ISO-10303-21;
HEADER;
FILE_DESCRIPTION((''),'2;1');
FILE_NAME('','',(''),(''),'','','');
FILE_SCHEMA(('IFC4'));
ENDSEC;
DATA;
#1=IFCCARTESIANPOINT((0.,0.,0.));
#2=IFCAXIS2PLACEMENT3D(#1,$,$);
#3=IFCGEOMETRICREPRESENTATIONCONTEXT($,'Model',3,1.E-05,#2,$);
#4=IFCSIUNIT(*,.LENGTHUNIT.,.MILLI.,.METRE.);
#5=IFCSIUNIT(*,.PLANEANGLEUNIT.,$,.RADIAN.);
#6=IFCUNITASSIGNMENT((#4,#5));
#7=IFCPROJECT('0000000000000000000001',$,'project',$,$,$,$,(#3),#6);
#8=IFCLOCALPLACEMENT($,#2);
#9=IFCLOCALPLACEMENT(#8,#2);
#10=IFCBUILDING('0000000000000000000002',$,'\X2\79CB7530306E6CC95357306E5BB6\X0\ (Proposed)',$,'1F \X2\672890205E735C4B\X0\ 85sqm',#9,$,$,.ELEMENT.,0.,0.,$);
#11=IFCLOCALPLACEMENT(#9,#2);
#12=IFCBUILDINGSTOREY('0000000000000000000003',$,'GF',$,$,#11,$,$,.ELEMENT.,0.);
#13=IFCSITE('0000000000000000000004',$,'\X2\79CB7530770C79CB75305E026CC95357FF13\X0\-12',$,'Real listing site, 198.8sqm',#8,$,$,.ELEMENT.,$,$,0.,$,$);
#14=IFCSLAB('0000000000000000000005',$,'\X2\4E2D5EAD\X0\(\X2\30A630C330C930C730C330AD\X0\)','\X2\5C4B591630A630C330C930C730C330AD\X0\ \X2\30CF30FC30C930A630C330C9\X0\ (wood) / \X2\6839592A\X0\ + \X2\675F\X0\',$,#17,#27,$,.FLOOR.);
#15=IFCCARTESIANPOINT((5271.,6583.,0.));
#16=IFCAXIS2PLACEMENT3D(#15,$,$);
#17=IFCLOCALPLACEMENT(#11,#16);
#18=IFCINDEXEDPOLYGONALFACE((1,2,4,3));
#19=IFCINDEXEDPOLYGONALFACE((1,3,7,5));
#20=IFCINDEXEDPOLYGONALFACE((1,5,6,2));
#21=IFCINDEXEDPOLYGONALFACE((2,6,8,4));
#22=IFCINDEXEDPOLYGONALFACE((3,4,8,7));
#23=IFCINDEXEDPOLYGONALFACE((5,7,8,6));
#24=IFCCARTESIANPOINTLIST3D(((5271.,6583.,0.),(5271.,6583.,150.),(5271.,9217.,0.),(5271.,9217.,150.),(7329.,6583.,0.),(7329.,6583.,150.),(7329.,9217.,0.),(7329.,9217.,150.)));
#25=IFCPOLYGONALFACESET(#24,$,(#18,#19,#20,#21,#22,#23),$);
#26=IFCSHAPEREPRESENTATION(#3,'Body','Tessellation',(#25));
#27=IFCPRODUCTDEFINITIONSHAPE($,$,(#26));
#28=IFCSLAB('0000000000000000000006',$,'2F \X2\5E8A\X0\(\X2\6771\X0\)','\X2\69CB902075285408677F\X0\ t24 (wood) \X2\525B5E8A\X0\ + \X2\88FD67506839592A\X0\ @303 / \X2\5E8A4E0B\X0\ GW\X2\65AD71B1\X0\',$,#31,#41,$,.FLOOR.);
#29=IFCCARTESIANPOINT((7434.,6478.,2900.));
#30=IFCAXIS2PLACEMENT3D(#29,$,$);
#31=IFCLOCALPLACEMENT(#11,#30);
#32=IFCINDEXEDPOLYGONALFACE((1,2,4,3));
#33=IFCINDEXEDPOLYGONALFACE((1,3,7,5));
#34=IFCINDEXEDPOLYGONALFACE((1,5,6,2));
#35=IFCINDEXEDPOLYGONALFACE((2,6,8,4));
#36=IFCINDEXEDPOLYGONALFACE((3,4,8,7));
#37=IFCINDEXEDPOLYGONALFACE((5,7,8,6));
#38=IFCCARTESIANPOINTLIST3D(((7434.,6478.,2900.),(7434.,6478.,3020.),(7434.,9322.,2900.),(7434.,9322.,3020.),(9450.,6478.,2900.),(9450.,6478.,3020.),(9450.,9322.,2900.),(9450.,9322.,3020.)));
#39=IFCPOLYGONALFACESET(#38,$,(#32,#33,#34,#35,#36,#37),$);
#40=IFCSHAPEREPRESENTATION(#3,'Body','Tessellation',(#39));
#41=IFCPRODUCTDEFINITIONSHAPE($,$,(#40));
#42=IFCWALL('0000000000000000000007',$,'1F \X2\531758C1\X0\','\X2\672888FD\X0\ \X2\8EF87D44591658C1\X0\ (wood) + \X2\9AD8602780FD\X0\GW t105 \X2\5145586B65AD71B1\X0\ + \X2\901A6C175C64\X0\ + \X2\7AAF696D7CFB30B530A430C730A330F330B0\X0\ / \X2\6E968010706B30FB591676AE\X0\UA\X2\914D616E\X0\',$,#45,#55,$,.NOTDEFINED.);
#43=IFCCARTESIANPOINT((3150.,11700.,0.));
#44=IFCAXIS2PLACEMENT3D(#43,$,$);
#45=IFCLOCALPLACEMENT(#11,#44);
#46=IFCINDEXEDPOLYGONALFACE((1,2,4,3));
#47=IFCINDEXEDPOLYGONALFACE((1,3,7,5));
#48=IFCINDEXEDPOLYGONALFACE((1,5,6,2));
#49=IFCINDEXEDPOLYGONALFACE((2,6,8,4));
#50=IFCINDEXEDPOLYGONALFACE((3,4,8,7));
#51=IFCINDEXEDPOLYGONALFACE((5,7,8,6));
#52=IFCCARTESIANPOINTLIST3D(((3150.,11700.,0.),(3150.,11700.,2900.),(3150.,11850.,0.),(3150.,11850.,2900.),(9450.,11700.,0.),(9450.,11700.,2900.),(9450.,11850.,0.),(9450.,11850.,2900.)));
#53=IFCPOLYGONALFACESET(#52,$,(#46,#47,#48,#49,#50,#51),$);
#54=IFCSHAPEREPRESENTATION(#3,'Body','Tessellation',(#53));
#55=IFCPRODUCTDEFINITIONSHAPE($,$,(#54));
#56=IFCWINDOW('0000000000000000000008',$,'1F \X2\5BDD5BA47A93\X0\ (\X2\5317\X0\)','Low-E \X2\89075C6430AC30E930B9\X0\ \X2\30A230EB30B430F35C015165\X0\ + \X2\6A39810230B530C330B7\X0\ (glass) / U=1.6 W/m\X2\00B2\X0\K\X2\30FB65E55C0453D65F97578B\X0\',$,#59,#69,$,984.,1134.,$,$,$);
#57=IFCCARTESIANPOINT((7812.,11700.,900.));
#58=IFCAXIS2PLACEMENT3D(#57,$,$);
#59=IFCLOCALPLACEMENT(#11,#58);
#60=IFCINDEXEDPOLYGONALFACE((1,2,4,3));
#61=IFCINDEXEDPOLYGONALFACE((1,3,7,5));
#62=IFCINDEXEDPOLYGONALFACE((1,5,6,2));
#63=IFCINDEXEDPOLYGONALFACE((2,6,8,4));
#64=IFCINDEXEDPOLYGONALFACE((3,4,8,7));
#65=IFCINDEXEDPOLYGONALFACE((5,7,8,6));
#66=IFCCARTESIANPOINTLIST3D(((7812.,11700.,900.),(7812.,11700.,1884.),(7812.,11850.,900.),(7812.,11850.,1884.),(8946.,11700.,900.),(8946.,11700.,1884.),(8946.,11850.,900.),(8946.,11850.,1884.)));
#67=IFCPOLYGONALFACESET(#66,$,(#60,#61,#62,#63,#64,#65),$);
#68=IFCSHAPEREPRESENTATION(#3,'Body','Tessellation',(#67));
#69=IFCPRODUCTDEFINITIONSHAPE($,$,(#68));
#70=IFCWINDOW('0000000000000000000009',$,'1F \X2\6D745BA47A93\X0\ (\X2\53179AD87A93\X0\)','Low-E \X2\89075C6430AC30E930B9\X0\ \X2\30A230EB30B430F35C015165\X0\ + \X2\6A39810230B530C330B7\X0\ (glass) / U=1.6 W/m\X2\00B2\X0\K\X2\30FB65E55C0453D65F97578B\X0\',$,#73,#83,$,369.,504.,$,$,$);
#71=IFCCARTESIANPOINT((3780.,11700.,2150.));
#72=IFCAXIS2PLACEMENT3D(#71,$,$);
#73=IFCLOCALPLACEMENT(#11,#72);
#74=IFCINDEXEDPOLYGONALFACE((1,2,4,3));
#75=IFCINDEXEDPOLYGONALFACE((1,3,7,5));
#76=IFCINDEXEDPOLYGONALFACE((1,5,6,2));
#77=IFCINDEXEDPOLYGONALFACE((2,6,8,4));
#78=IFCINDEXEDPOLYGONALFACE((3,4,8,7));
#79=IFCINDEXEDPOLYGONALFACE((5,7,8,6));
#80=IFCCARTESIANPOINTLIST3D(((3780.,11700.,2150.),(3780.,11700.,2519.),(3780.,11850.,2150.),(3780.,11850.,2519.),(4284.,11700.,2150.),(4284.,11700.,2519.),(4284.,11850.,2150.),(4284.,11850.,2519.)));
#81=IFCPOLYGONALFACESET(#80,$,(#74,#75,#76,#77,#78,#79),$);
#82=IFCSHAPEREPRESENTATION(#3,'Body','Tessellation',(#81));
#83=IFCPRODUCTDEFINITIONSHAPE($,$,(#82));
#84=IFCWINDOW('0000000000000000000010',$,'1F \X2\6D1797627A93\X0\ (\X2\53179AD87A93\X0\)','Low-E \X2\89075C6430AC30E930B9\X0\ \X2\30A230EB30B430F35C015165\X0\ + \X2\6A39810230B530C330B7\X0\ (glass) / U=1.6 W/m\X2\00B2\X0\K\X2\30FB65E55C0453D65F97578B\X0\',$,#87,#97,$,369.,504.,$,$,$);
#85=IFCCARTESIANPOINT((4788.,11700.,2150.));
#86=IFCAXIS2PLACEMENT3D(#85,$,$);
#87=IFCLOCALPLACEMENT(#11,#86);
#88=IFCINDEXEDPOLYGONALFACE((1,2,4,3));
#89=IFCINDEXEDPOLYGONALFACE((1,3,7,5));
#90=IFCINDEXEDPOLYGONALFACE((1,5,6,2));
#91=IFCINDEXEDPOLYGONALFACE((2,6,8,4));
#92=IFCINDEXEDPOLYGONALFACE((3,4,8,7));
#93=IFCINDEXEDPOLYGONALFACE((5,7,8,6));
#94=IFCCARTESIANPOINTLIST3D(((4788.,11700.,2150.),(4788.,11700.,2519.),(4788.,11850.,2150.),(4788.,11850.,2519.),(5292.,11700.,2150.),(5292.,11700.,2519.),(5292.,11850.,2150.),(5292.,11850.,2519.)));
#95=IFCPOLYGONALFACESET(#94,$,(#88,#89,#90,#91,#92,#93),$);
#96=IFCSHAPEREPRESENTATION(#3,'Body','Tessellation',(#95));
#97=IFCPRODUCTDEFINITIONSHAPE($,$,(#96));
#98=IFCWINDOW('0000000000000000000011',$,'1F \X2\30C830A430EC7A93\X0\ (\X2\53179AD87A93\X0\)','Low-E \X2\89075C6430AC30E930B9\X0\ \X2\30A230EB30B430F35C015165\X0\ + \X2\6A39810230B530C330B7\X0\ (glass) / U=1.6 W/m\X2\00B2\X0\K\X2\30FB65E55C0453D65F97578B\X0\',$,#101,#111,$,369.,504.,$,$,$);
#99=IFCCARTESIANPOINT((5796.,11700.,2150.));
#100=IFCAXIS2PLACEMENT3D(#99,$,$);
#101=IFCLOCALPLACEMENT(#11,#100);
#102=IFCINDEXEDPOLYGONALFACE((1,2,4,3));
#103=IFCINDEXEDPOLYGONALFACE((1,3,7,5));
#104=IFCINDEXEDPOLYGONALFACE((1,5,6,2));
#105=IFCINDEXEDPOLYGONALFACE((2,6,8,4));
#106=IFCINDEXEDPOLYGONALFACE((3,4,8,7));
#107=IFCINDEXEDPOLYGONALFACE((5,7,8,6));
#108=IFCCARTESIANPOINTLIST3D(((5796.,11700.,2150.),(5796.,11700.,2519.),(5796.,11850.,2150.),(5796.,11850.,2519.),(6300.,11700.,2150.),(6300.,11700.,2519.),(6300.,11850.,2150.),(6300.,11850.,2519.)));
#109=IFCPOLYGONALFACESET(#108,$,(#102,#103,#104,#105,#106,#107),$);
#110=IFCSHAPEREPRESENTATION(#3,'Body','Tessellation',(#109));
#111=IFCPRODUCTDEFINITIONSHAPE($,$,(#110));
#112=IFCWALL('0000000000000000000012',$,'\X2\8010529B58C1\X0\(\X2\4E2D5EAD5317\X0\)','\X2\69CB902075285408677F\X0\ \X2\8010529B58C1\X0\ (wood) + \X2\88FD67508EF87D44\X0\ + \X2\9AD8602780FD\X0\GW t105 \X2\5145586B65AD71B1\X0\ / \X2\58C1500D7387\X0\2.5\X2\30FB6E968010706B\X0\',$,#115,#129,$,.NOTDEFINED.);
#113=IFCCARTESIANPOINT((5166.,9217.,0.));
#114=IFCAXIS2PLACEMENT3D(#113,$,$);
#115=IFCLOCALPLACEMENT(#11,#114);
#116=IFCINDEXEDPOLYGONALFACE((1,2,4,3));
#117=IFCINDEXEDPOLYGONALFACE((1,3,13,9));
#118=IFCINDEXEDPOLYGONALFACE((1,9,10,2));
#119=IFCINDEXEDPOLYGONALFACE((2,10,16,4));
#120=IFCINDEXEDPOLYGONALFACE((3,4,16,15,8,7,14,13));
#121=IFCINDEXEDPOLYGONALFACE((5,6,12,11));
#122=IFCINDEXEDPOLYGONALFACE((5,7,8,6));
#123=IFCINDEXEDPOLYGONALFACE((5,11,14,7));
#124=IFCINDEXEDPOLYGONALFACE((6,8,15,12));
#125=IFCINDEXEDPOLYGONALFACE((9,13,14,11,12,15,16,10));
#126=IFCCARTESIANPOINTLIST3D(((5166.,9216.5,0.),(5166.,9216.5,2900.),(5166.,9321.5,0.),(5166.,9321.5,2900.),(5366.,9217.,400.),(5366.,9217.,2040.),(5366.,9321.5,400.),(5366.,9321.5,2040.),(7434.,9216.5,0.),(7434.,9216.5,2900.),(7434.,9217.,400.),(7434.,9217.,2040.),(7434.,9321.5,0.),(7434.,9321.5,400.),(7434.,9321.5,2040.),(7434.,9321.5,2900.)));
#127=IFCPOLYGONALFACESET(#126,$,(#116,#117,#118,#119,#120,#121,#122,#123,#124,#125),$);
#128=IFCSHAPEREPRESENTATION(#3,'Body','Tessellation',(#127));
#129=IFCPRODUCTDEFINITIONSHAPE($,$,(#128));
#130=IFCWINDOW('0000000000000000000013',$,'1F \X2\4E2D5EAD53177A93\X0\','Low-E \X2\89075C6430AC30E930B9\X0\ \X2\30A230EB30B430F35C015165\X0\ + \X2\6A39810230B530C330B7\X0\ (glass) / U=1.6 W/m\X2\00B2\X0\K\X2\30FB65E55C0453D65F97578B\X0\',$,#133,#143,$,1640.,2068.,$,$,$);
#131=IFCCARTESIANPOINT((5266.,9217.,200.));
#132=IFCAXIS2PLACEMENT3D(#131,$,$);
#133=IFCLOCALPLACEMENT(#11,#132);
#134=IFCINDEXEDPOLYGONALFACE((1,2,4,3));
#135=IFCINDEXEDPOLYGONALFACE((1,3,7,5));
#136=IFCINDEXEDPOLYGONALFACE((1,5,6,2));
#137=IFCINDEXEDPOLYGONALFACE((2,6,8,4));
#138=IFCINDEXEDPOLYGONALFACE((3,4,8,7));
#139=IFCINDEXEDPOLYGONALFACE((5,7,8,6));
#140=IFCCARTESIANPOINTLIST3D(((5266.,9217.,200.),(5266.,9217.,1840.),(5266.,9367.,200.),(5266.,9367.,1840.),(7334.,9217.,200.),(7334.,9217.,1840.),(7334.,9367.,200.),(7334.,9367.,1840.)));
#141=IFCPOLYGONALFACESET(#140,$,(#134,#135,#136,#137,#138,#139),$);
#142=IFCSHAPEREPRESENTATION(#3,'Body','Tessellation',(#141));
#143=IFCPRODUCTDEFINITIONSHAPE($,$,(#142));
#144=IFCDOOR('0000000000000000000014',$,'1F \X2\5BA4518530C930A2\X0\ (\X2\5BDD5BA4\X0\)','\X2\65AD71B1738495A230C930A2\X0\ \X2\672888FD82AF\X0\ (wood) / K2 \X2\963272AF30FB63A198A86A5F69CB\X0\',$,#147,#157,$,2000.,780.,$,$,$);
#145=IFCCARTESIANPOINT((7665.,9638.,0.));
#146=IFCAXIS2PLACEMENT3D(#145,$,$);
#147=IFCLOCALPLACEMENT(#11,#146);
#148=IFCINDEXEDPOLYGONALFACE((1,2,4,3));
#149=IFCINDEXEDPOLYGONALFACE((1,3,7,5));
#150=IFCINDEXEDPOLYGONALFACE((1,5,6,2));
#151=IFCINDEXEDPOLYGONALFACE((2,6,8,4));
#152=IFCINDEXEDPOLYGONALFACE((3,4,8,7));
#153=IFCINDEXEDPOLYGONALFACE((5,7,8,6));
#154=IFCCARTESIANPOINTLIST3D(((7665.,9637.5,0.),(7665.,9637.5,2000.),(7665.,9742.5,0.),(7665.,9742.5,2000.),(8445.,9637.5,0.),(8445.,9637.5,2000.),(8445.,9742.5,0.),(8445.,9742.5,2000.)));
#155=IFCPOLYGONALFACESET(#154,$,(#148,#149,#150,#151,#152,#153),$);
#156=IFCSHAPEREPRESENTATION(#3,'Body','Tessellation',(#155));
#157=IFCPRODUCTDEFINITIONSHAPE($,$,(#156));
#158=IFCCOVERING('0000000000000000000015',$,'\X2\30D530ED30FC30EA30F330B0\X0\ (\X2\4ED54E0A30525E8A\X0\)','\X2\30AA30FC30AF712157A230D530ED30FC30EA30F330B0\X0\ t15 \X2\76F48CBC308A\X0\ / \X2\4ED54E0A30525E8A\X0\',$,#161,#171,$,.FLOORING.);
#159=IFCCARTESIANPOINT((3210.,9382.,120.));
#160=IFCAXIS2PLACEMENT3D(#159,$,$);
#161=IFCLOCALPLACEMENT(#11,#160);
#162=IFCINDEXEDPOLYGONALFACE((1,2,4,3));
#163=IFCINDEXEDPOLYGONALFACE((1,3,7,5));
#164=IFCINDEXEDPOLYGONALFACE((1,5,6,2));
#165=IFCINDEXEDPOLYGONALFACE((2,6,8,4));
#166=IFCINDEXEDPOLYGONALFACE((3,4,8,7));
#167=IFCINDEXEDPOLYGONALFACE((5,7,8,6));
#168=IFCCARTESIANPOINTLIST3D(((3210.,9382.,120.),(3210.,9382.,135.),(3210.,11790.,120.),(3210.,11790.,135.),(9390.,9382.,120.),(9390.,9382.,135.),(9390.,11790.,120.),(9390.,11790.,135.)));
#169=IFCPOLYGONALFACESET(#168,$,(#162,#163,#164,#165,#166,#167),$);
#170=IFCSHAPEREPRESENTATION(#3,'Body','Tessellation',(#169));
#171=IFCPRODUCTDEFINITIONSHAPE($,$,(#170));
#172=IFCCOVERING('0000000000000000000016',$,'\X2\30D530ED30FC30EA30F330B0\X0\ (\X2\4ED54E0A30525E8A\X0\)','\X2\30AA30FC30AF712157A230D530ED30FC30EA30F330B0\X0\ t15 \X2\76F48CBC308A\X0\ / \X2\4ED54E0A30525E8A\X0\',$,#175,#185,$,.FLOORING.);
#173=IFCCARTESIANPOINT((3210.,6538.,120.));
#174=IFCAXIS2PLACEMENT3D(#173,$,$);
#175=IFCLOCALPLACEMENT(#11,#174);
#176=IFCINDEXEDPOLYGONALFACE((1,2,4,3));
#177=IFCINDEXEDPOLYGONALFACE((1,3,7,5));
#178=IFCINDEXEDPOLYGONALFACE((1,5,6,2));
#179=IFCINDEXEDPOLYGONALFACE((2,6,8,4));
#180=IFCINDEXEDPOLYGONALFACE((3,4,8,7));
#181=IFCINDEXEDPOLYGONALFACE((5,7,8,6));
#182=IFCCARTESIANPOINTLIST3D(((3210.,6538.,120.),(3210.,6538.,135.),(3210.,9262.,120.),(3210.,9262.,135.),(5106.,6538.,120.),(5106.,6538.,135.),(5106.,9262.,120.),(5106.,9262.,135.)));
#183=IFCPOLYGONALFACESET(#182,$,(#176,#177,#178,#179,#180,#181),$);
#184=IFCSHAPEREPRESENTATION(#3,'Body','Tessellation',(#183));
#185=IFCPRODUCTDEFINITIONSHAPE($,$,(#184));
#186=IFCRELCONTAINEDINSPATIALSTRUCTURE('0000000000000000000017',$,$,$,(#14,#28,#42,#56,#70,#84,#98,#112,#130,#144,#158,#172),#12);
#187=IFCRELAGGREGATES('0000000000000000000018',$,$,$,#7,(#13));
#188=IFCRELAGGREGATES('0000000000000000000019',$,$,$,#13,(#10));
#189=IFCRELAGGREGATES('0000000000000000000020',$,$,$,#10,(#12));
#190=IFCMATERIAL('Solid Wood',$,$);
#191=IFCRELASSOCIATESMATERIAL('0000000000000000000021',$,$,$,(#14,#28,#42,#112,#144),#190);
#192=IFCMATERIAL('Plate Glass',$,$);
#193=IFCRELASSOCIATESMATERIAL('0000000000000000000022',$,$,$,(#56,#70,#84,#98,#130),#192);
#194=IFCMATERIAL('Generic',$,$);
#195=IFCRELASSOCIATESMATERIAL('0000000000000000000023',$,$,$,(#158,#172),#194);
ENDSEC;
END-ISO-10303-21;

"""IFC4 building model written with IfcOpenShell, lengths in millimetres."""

from ifc_helpers import new_model, si_unit, frame, frame_2d, origin, place, context, project, spatial, rectangle, extrude, material, element, fill, save


model = new_model("IFC4")

# Units and contexts
model_context = context("Model", 3, precision=1e-05, world=origin())
ifc_project = project(units=[si_unit("LENGTHUNIT", "METRE", prefix="MILLI"), si_unit("PLANEANGLEUNIT", "RADIAN")], contexts=[model_context])

# Site, building, storey
site_placement = place(None, origin())
site = spatial("IfcSite", under=ifc_project, at=site_placement, Name="秋田県秋田市泉南３-12", ObjectType="Real listing site, 198.8sqm", CompositionType="ELEMENT", RefElevation=0.0)
building_placement = place(site_placement, origin())
building = spatial("IfcBuilding", under=site, at=building_placement, Name="秋田の泉南の家 (Proposed)", ObjectType="1F 木造平屋 85sqm", CompositionType="ELEMENT", ElevationOfRefHeight=0.0, ElevationOfTerrain=0.0)
storey_placement = place(building_placement, origin())
storey = spatial("IfcBuildingStorey", under=building, at=storey_placement, Name="GF", CompositionType="ELEMENT", Elevation=0.0)

# Slabs
ifc_material_1 = material(Name="Solid Wood")
slab_1_placement = place(storey_placement, frame((5271.0, 6583.0, 0.0)))
element("IfcSlab", 1, at=slab_1_placement, inside=storey, material=ifc_material_1, Name="中庭(ウッドデッキ)", Description="屋外ウッドデッキ ハードウッド (wood) / 根太 + 束", PredefinedType="FLOOR", context=model_context, shape_type="SweptSolid", body=[
    extrude(rectangle(XDim=2058.0, YDim=2634.0, at=frame_2d((1029.0, 1317.0))), frame((5271.0, 6583.0, 0.0)), (0.0, 0.0, 1.0), 150.0),
])
slab_2_placement = place(storey_placement, frame((7434.0, 6478.0, 2900.0)))
element("IfcSlab", 2, at=slab_2_placement, inside=storey, material=ifc_material_1, Name="2F 床(東)", Description="構造用合板 t24 (wood) 剛床 + 製材根太 @303 / 床下 GW断熱", PredefinedType="FLOOR", context=model_context, shape_type="SweptSolid", body=[
    extrude(rectangle(XDim=2016.0, YDim=2844.0, at=frame_2d((1008.0, 1422.0))), frame((7434.0, 6478.0, 2900.0)), (0.0, 0.0, 1.0), 120.0),
])

# Wall, openings, windows
wall_1_placement = place(storey_placement, frame((3150.0, 11700.0, 0.0)))
wall_1 = element("IfcWall", 3, at=wall_1_placement, inside=storey, material=ifc_material_1, Name="1F 北壁", Description="木製 軸組外壁 (wood) + 高性能GW t105 充填断熱 + 通気層 + 窯業系サイディング / 準耐火・外皮UA配慮", PredefinedType="NOTDEFINED", context=model_context, shape_type="SweptSolid", body=[
    extrude(rectangle(XDim=6300.0, YDim=150.0, at=frame_2d((3150.0, 75.0))), frame((3150.0, 11700.0, 0.0)), (0.0, 0.0, 1.0), 2900.0),
])
opening_1_placement = place(storey_placement, frame((7812.0, 11700.0, 900.0)))
opening_1 = element("IfcOpeningElement", 4, at=opening_1_placement, cuts=wall_1, PredefinedType="NOTDEFINED", context=model_context, shape_type="SweptSolid", body=[
    extrude(rectangle(XDim=1134.0, YDim=150.0, at=frame_2d((567.0, 75.0))), frame((7812.0, 11700.0, 900.0)), (0.0, 0.0, 1.0), 984.0),
])
opening_2_placement = place(storey_placement, frame((3780.0, 11700.0, 2150.0)))
opening_2 = element("IfcOpeningElement", 5, at=opening_2_placement, cuts=wall_1, PredefinedType="NOTDEFINED", context=model_context, shape_type="SweptSolid", body=[
    extrude(rectangle(XDim=504.0, YDim=150.0, at=frame_2d((252.0, 75.0))), frame((3780.0, 11700.0, 2150.0)), (0.0, 0.0, 1.0), 369.0),
])
opening_3_placement = place(storey_placement, frame((4788.0, 11700.0, 2150.0)))
opening_3 = element("IfcOpeningElement", 6, at=opening_3_placement, cuts=wall_1, PredefinedType="NOTDEFINED", context=model_context, shape_type="SweptSolid", body=[
    extrude(rectangle(XDim=504.0, YDim=150.0, at=frame_2d((252.0, 75.0))), frame((4788.0, 11700.0, 2150.0)), (0.0, 0.0, 1.0), 369.0),
])
opening_4_placement = place(storey_placement, frame((5796.0, 11700.0, 2150.0)))
opening_4 = element("IfcOpeningElement", 7, at=opening_4_placement, cuts=wall_1, PredefinedType="NOTDEFINED", context=model_context, shape_type="SweptSolid", body=[
    extrude(rectangle(XDim=504.0, YDim=150.0, at=frame_2d((252.0, 75.0))), frame((5796.0, 11700.0, 2150.0)), (0.0, 0.0, 1.0), 369.0),
])
ifc_material_2 = material(Name="Plate Glass")
window_1_placement = place(storey_placement, frame((7812.0, 11700.0, 900.0)))
window_1 = element("IfcWindow", 8, at=window_1_placement, inside=storey, material=ifc_material_2, Name="1F 寝室窓 (北)", Description="Low-E 複層ガラス アルゴン封入 + 樹脂サッシ (glass) / U=1.6 W/m²K・日射取得型", OverallHeight=984.0, OverallWidth=1134.0, context=model_context, shape_type="SweptSolid", body=[
    extrude(rectangle(XDim=1134.0, YDim=150.0, at=frame_2d((567.0, 75.0))), frame((7812.0, 11700.0, 900.0)), (0.0, 0.0, 1.0), 984.0),
])
fill(opening_1, window_1)
window_2_placement = place(storey_placement, frame((3780.0, 11700.0, 2150.0)))
window_2 = element("IfcWindow", 9, at=window_2_placement, inside=storey, material=ifc_material_2, Name="1F 浴室窓 (北高窓)", Description="Low-E 複層ガラス アルゴン封入 + 樹脂サッシ (glass) / U=1.6 W/m²K・日射取得型", OverallHeight=369.0, OverallWidth=504.0, context=model_context, shape_type="SweptSolid", body=[
    extrude(rectangle(XDim=504.0, YDim=150.0, at=frame_2d((252.0, 75.0))), frame((3780.0, 11700.0, 2150.0)), (0.0, 0.0, 1.0), 369.0),
])
fill(opening_2, window_2)
window_3_placement = place(storey_placement, frame((4788.0, 11700.0, 2150.0)))
window_3 = element("IfcWindow", 10, at=window_3_placement, inside=storey, material=ifc_material_2, Name="1F 洗面窓 (北高窓)", Description="Low-E 複層ガラス アルゴン封入 + 樹脂サッシ (glass) / U=1.6 W/m²K・日射取得型", OverallHeight=369.0, OverallWidth=504.0, context=model_context, shape_type="SweptSolid", body=[
    extrude(rectangle(XDim=504.0, YDim=150.0, at=frame_2d((252.0, 75.0))), frame((4788.0, 11700.0, 2150.0)), (0.0, 0.0, 1.0), 369.0),
])
fill(opening_3, window_3)
window_4_placement = place(storey_placement, frame((5796.0, 11700.0, 2150.0)))
window_4 = element("IfcWindow", 11, at=window_4_placement, inside=storey, material=ifc_material_2, Name="1F トイレ窓 (北高窓)", Description="Low-E 複層ガラス アルゴン封入 + 樹脂サッシ (glass) / U=1.6 W/m²K・日射取得型", OverallHeight=369.0, OverallWidth=504.0, context=model_context, shape_type="SweptSolid", body=[
    extrude(rectangle(XDim=504.0, YDim=150.0, at=frame_2d((252.0, 75.0))), frame((5796.0, 11700.0, 2150.0)), (0.0, 0.0, 1.0), 369.0),
])
fill(opening_4, window_4)

# Wall, opening, window
wall_2_placement = place(storey_placement, frame((5166.0, 9217.0, 0.0)))
wall_2 = element("IfcWall", 12, at=wall_2_placement, inside=storey, material=ifc_material_1, Name="耐力壁(中庭北)", Description="構造用合板 耐力壁 (wood) + 製材軸組 + 高性能GW t105 充填断熱 / 壁倍率2.5・準耐火", PredefinedType="NOTDEFINED", context=model_context, shape_type="SweptSolid", body=[
    extrude(rectangle(XDim=2268.0, YDim=105.0, at=frame_2d((1134.0, 52.0))), frame((5166.0, 9217.0, 0.0)), (0.0, 0.0, 1.0), 2900.0),
])
opening_5_placement = place(storey_placement, frame((5266.0, 9217.0, 200.0)))
opening_5 = element("IfcOpeningElement", 13, at=opening_5_placement, cuts=wall_2, PredefinedType="NOTDEFINED", context=model_context, shape_type="SweptSolid", body=[
    extrude(rectangle(XDim=2068.0, YDim=150.0, at=frame_2d((1034.0, 75.0))), frame((5266.0, 9217.0, 200.0)), (0.0, 0.0, 1.0), 1640.0),
])
window_5_placement = place(storey_placement, frame((5266.0, 9217.0, 200.0)))
window_5 = element("IfcWindow", 14, at=window_5_placement, inside=storey, material=ifc_material_2, Name="1F 中庭北窓", Description="Low-E 複層ガラス アルゴン封入 + 樹脂サッシ (glass) / U=1.6 W/m²K・日射取得型", OverallHeight=1640.0, OverallWidth=2068.0, context=model_context, shape_type="SweptSolid", body=[
    extrude(rectangle(XDim=2068.0, YDim=150.0, at=frame_2d((1034.0, 75.0))), frame((5266.0, 9217.0, 200.0)), (0.0, 0.0, 1.0), 1640.0),
])
fill(opening_5, window_5)

# Door
door_1_placement = place(storey_placement, frame((7665.0, 9638.0, 0.0)))
element("IfcDoor", 15, at=door_1_placement, inside=storey, material=ifc_material_1, Name="1F 室内ドア (寝室)", Description="断熱玄関ドア 木製芯 (wood) / K2 防犯・採風機構", OverallHeight=2000.0, OverallWidth=780.0, context=model_context, shape_type="SweptSolid", body=[
    extrude(rectangle(XDim=780.0, YDim=105.0, at=frame_2d((390.0, 52.0))), frame((7665.0, 9638.0, 0.0)), (0.0, 0.0, 1.0), 2000.0),
])

# Coverings
ifc_material_3 = material(Name="Generic")
covering_1_placement = place(storey_placement, frame((3210.0, 9382.0, 120.0)))
element("IfcCovering", 16, at=covering_1_placement, inside=storey, material=ifc_material_3, Name="フローリング (仕上げ床)", Description="オーク無垢フローリング t15 直貼り / 仕上げ床", PredefinedType="FLOORING", context=model_context, shape_type="SweptSolid", body=[
    extrude(rectangle(XDim=6180.0, YDim=2408.0, at=frame_2d((3090.0, 1204.0))), frame((3210.0, 9382.0, 120.0)), (0.0, 0.0, 1.0), 15.0),
])
covering_2_placement = place(storey_placement, frame((3210.0, 6538.0, 120.0)))
element("IfcCovering", 17, at=covering_2_placement, inside=storey, material=ifc_material_3, Name="フローリング (仕上げ床)", Description="オーク無垢フローリング t15 直貼り / 仕上げ床", PredefinedType="FLOORING", context=model_context, shape_type="SweptSolid", body=[
    extrude(rectangle(XDim=1896.0, YDim=2724.0, at=frame_2d((948.0, 1362.0))), frame((3210.0, 6538.0, 120.0)), (0.0, 0.0, 1.0), 15.0),
])

save(model, "model.ifc")
